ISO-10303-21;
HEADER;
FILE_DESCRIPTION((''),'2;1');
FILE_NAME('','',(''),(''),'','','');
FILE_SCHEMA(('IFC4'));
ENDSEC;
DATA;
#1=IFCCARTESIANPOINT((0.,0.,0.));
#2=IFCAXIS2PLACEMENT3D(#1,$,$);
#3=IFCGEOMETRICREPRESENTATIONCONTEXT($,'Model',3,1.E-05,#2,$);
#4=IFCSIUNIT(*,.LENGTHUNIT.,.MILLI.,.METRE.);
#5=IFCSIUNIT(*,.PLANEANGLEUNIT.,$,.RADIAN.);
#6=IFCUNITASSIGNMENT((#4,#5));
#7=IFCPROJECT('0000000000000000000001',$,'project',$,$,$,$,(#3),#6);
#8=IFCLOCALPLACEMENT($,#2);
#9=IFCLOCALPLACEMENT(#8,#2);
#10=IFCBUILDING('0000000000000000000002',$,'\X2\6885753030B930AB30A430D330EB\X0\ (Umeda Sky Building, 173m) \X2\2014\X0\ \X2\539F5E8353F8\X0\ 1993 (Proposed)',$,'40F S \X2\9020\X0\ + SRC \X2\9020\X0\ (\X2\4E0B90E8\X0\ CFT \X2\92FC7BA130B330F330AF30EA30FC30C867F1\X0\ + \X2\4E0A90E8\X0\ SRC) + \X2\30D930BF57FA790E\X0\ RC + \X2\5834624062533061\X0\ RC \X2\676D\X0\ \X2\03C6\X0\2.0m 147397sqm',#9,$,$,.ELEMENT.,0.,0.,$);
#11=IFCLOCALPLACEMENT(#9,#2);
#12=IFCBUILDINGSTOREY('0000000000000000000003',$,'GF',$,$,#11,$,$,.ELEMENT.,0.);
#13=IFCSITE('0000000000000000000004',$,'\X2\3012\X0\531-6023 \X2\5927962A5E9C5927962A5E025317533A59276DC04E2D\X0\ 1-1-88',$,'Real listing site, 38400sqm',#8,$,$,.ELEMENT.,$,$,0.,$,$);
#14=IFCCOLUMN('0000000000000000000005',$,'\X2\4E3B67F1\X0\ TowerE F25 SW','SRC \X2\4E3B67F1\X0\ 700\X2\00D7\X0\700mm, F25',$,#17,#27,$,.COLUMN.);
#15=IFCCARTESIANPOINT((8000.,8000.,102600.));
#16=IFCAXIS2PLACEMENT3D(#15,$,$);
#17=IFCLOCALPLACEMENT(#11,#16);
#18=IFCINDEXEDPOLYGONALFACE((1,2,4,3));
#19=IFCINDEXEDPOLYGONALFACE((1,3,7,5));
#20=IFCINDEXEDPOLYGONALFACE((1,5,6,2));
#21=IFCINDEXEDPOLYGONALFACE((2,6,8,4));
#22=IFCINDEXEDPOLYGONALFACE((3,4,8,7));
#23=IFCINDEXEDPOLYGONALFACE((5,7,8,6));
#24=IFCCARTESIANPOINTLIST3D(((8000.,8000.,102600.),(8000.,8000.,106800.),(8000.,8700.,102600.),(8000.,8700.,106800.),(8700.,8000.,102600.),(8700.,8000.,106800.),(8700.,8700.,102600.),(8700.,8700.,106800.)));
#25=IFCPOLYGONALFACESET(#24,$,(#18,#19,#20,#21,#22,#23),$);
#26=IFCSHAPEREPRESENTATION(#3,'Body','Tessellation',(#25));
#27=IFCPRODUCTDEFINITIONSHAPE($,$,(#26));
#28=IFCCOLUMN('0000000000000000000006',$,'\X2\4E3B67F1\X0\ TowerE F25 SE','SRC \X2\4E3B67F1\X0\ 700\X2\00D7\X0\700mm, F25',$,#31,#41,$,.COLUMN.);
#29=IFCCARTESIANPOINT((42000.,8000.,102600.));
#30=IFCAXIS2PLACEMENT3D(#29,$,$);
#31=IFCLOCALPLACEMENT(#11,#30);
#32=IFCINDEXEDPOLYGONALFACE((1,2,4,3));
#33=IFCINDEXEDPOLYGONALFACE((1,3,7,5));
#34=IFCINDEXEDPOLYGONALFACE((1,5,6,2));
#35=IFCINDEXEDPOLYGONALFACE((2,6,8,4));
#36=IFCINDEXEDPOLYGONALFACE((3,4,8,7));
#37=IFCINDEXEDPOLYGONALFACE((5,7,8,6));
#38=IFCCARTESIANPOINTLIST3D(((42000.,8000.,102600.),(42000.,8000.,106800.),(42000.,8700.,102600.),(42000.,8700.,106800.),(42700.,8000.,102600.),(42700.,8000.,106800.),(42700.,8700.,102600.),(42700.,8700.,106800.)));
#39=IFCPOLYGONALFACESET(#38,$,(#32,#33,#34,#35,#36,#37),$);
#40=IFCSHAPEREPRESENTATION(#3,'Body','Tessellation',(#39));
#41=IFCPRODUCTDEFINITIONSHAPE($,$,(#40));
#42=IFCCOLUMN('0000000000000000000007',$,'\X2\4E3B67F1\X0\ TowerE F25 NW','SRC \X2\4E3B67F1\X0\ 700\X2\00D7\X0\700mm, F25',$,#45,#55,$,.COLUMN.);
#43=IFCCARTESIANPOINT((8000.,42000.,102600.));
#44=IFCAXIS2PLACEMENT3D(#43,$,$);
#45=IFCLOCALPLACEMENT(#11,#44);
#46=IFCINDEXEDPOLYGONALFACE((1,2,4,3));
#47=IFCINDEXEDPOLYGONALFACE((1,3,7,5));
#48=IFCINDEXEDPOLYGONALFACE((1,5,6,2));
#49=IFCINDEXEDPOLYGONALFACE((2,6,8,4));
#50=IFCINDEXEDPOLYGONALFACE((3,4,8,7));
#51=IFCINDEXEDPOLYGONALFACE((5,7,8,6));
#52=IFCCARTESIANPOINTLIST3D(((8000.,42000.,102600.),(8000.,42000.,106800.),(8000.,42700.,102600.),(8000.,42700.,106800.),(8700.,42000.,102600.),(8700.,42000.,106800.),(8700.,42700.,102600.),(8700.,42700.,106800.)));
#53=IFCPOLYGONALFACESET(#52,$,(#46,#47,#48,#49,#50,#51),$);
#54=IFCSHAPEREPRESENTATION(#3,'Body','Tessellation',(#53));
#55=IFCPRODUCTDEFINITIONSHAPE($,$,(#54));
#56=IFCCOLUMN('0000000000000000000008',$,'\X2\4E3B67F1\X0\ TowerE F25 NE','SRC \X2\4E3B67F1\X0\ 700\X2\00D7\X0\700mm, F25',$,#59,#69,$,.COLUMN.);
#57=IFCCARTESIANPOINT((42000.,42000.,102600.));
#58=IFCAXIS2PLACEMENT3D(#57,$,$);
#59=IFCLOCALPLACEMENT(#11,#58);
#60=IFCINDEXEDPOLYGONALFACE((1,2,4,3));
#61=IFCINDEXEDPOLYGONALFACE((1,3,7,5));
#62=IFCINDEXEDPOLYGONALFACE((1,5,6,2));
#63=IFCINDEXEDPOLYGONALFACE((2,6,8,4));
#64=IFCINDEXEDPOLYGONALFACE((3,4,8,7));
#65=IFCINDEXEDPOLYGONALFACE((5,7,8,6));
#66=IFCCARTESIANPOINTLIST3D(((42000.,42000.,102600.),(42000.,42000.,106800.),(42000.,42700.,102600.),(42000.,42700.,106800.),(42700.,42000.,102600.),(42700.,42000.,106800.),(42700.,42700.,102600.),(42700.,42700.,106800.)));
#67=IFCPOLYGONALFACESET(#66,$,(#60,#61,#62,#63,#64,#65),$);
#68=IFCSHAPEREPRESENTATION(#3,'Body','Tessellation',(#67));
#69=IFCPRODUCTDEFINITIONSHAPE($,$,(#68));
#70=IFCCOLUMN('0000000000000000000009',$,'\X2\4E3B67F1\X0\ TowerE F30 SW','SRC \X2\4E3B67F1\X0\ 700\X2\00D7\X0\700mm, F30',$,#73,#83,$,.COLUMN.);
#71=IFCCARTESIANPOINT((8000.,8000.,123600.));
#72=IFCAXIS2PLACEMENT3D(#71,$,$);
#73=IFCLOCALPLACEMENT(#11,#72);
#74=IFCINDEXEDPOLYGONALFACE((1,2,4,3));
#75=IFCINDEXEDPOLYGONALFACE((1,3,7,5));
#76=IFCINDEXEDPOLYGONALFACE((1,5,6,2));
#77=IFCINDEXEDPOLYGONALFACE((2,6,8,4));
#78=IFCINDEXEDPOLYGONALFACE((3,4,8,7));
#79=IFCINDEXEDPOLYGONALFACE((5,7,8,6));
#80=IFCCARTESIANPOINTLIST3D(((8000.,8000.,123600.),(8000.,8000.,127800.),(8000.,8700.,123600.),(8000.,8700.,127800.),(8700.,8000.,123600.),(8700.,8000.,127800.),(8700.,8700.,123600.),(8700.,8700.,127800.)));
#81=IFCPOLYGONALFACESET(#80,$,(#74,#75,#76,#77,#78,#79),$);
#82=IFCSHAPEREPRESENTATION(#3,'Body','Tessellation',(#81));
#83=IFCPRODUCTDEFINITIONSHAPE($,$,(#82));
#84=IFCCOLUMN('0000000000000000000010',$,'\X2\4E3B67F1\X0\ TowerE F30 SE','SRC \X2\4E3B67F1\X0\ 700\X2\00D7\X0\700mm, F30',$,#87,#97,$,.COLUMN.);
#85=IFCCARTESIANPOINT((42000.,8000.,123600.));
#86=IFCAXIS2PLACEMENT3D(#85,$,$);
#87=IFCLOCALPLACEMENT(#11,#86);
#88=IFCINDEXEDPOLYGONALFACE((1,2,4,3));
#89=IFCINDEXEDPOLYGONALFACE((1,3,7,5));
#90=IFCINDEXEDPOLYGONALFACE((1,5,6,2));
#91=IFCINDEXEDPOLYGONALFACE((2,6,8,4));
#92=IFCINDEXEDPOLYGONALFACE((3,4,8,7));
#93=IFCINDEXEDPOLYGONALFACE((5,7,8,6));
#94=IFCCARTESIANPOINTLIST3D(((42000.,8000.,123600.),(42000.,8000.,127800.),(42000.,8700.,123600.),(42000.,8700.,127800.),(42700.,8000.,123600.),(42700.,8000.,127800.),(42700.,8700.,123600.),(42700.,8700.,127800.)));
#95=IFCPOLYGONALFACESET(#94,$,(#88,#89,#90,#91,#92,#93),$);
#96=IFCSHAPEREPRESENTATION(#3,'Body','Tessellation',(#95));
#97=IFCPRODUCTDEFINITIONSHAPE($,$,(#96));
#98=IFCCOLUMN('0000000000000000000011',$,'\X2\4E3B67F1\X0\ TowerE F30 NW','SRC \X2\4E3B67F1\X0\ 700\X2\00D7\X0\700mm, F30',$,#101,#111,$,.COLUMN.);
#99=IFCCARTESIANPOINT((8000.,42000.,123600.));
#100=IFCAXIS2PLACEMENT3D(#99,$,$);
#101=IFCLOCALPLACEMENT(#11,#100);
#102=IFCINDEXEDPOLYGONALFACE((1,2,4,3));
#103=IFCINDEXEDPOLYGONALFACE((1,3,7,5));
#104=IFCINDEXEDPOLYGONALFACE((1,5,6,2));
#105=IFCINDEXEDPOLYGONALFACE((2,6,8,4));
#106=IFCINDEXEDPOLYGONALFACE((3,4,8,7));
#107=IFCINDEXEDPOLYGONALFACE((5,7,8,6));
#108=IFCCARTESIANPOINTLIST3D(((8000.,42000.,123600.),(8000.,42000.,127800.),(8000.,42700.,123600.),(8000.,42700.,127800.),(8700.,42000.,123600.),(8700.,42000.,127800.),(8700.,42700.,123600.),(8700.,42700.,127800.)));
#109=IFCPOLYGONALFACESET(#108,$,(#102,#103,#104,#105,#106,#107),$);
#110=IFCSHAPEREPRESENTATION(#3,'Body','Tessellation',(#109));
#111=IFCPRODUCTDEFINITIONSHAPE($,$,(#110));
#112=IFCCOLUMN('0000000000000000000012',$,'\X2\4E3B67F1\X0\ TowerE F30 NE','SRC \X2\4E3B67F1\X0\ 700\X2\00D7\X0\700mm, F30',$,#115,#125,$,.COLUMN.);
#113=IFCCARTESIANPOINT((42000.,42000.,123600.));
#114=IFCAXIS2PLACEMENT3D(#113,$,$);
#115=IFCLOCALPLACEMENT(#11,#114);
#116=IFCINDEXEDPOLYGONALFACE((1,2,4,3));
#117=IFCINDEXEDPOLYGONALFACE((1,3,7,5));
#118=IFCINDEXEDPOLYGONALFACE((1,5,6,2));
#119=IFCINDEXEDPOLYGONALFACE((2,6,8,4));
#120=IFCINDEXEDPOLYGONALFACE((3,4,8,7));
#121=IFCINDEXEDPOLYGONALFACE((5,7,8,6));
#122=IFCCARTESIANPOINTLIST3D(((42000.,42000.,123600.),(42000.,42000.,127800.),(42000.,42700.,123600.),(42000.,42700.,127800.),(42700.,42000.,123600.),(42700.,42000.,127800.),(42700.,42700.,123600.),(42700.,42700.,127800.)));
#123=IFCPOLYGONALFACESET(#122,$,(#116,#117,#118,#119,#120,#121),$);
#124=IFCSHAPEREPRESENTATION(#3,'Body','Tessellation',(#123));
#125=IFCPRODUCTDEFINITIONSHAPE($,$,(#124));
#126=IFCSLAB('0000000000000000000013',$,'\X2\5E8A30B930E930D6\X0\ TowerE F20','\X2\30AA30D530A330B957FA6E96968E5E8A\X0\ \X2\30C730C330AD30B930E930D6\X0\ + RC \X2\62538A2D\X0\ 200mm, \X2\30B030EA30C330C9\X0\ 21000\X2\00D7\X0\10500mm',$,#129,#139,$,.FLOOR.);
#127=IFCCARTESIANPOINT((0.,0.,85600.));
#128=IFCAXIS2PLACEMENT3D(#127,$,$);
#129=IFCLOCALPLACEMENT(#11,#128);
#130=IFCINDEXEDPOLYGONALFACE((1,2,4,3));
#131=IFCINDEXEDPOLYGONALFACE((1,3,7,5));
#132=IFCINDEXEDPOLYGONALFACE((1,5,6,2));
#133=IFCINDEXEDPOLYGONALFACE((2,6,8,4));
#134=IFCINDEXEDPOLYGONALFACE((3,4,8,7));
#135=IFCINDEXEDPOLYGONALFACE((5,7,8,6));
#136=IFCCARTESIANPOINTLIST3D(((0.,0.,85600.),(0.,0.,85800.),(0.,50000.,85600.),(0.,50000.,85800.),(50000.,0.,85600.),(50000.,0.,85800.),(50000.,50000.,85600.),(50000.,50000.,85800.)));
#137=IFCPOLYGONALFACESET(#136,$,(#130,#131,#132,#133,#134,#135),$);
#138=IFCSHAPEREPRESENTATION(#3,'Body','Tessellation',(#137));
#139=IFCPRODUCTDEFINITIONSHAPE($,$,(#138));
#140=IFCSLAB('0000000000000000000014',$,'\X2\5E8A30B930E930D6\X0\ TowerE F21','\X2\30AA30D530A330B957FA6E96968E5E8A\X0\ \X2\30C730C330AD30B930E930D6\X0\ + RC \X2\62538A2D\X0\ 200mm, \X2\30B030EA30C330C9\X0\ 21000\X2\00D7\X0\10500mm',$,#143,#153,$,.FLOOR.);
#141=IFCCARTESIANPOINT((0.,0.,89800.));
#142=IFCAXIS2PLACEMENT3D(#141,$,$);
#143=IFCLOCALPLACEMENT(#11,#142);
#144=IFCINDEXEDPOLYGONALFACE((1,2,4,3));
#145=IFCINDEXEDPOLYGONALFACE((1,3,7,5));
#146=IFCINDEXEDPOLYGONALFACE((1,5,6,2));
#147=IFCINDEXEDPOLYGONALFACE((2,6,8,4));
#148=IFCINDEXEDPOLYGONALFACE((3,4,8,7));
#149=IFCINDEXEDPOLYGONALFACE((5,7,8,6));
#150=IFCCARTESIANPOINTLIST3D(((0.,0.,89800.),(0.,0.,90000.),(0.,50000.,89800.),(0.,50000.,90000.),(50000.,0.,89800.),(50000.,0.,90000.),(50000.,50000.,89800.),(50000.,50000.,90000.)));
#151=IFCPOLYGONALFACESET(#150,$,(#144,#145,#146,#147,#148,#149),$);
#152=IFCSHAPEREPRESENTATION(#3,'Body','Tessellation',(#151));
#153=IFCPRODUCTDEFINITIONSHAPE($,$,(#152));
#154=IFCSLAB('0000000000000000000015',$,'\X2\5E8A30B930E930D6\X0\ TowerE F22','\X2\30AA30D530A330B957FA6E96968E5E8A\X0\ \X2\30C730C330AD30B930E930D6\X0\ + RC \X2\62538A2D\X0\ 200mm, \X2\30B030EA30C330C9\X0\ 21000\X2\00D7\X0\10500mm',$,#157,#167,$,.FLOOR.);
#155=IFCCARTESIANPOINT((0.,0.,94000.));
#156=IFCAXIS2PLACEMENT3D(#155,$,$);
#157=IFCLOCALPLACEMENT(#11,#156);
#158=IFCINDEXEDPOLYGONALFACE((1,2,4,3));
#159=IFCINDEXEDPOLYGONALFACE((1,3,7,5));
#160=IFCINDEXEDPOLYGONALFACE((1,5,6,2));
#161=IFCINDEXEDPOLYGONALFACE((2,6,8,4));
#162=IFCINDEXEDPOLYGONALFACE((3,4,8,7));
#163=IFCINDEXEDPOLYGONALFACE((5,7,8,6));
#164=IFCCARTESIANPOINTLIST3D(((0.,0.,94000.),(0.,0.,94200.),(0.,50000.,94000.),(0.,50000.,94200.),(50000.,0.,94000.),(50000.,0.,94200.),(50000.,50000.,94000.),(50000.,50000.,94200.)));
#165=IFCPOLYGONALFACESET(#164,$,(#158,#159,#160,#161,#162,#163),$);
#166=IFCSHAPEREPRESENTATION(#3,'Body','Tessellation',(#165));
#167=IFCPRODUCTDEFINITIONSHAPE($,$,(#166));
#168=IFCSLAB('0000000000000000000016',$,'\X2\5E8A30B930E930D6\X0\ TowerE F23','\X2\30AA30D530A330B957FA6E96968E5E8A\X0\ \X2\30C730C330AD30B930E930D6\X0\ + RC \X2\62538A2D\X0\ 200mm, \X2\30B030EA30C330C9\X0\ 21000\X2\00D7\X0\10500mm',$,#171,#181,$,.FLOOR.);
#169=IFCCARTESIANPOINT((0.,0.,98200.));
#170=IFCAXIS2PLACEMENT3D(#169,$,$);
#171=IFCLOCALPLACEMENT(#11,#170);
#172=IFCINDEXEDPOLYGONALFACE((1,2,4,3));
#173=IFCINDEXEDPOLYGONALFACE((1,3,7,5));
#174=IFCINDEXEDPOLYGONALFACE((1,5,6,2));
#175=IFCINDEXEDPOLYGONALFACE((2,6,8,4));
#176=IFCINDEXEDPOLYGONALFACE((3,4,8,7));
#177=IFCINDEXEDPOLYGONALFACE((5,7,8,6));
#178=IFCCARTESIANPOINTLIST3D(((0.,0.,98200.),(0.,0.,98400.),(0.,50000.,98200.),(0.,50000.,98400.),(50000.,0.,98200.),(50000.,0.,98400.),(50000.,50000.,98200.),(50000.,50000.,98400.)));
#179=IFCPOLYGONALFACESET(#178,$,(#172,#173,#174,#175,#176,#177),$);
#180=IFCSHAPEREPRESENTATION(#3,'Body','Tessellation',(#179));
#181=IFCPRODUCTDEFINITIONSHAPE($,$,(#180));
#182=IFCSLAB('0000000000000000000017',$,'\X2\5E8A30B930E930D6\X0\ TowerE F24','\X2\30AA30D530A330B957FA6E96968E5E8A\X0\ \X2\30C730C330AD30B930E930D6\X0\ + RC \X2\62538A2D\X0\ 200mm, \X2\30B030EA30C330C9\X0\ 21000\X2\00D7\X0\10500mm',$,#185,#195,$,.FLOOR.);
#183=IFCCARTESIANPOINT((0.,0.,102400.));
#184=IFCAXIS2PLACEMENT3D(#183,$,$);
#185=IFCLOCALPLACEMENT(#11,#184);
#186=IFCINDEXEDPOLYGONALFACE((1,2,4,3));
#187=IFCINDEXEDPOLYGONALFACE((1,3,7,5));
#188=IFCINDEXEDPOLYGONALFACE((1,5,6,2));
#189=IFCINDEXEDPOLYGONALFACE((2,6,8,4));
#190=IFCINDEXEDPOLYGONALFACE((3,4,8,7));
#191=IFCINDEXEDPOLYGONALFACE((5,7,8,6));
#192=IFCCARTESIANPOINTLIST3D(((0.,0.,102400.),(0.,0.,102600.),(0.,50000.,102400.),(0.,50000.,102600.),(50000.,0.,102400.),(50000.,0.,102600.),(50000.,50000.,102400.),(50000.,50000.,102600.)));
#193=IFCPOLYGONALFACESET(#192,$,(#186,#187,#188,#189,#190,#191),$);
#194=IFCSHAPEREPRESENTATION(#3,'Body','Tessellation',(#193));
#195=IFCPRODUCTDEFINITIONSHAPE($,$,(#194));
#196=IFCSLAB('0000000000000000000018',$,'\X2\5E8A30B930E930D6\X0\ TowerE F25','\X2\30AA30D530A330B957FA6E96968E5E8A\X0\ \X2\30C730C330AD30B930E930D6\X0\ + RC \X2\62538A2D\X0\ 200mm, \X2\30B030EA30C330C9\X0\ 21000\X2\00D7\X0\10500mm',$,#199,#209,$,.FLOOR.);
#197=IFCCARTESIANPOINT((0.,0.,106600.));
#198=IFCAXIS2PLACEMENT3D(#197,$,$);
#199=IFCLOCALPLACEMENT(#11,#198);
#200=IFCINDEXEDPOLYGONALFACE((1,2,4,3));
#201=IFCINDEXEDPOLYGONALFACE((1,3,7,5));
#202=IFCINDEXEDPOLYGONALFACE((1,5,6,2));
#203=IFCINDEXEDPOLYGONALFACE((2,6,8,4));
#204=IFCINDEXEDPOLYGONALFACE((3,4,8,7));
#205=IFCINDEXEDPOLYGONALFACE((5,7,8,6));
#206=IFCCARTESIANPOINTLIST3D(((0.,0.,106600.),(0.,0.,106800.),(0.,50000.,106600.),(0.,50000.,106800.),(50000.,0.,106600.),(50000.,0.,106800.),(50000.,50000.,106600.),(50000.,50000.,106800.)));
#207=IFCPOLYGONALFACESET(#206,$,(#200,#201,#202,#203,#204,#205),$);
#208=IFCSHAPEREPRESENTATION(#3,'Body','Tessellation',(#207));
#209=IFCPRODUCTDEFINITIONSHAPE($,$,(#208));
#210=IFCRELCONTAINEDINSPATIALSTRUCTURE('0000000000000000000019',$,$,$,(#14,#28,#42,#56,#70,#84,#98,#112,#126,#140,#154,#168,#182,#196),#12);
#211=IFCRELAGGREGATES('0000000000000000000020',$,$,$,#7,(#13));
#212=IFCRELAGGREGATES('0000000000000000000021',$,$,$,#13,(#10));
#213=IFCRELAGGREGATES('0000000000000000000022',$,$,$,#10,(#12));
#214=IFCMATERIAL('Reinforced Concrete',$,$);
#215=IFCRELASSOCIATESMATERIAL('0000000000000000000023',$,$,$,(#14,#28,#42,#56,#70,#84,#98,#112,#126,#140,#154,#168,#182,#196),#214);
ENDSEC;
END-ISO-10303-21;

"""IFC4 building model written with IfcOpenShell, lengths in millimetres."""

from ifc_helpers import new_model, si_unit, frame, frame_2d, origin, place, context, project, spatial, rectangle, extrude, material, element, save


model = new_model("IFC4")

# Units and contexts
model_context = context("Model", 3, precision=1e-05, world=origin())
ifc_project = project(units=[si_unit("LENGTHUNIT", "METRE", prefix="MILLI"), si_unit("PLANEANGLEUNIT", "RADIAN")], contexts=[model_context])

# Site, building, storey
site_placement = place(None, origin())
site = spatial("IfcSite", under=ifc_project, at=site_placement, Name="〒531-6023 大阪府大阪市北区大淀中 1-1-88", ObjectType="Real listing site, 38400sqm", CompositionType="ELEMENT", RefElevation=0.0)
building_placement = place(site_placement, origin())
building = spatial("IfcBuilding", under=site, at=building_placement, Name="梅田スカイビル (Umeda Sky Building, 173m) — 原広司 1993 (Proposed)", ObjectType="40F S 造 + SRC 造 (下部 CFT 鋼管コンクリート柱 + 上部 SRC) + ベタ基礎 RC + 場所打ち RC 杭 φ2.0m 147397sqm", CompositionType="ELEMENT", ElevationOfRefHeight=0.0, ElevationOfTerrain=0.0)
storey_placement = place(building_placement, origin())
storey = spatial("IfcBuildingStorey", under=building, at=storey_placement, Name="GF", CompositionType="ELEMENT", Elevation=0.0)

# Columns
ifc_material_1 = material(Name="Reinforced Concrete")
column_1_placement = place(storey_placement, frame((8000.0, 8000.0, 102600.0)))
element("IfcColumn", 1, at=column_1_placement, inside=storey, material=ifc_material_1, Name="主柱 TowerE F25 SW", Description="SRC 主柱 700×700mm, F25", PredefinedType="COLUMN", context=model_context, shape_type="SweptSolid", body=[
    extrude(rectangle(XDim=700.0, YDim=700.0, at=frame_2d((350.0, 350.0))), frame((8000.0, 8000.0, 102600.0)), (0.0, 0.0, 1.0), 4200.0),
])
column_2_placement = place(storey_placement, frame((42000.0, 8000.0, 102600.0)))
element("IfcColumn", 2, at=column_2_placement, inside=storey, material=ifc_material_1, Name="主柱 TowerE F25 SE", Description="SRC 主柱 700×700mm, F25", PredefinedType="COLUMN", context=model_context, shape_type="SweptSolid", body=[
    extrude(rectangle(XDim=700.0, YDim=700.0, at=frame_2d((350.0, 350.0))), frame((42000.0, 8000.0, 102600.0)), (0.0, 0.0, 1.0), 4200.0),
])
column_3_placement = place(storey_placement, frame((8000.0, 42000.0, 102600.0)))
element("IfcColumn", 3, at=column_3_placement, inside=storey, material=ifc_material_1, Name="主柱 TowerE F25 NW", Description="SRC 主柱 700×700mm, F25", PredefinedType="COLUMN", context=model_context, shape_type="SweptSolid", body=[
    extrude(rectangle(XDim=700.0, YDim=700.0, at=frame_2d((350.0, 350.0))), frame((8000.0, 42000.0, 102600.0)), (0.0, 0.0, 1.0), 4200.0),
])
column_4_placement = place(storey_placement, frame((42000.0, 42000.0, 102600.0)))
element("IfcColumn", 4, at=column_4_placement, inside=storey, material=ifc_material_1, Name="主柱 TowerE F25 NE", Description="SRC 主柱 700×700mm, F25", PredefinedType="COLUMN", context=model_context, shape_type="SweptSolid", body=[
    extrude(rectangle(XDim=700.0, YDim=700.0, at=frame_2d((350.0, 350.0))), frame((42000.0, 42000.0, 102600.0)), (0.0, 0.0, 1.0), 4200.0),
])
column_5_placement = place(storey_placement, frame((8000.0, 8000.0, 123600.0)))
element("IfcColumn", 5, at=column_5_placement, inside=storey, material=ifc_material_1, Name="主柱 TowerE F30 SW", Description="SRC 主柱 700×700mm, F30", PredefinedType="COLUMN", context=model_context, shape_type="SweptSolid", body=[
    extrude(rectangle(XDim=700.0, YDim=700.0, at=frame_2d((350.0, 350.0))), frame((8000.0, 8000.0, 123600.0)), (0.0, 0.0, 1.0), 4200.0),
])
column_6_placement = place(storey_placement, frame((42000.0, 8000.0, 123600.0)))
element("IfcColumn", 6, at=column_6_placement, inside=storey, material=ifc_material_1, Name="主柱 TowerE F30 SE", Description="SRC 主柱 700×700mm, F30", PredefinedType="COLUMN", context=model_context, shape_type="SweptSolid", body=[
    extrude(rectangle(XDim=700.0, YDim=700.0, at=frame_2d((350.0, 350.0))), frame((42000.0, 8000.0, 123600.0)), (0.0, 0.0, 1.0), 4200.0),
])
column_7_placement = place(storey_placement, frame((8000.0, 42000.0, 123600.0)))
element("IfcColumn", 7, at=column_7_placement, inside=storey, material=ifc_material_1, Name="主柱 TowerE F30 NW", Description="SRC 主柱 700×700mm, F30", PredefinedType="COLUMN", context=model_context, shape_type="SweptSolid", body=[
    extrude(rectangle(XDim=700.0, YDim=700.0, at=frame_2d((350.0, 350.0))), frame((8000.0, 42000.0, 123600.0)), (0.0, 0.0, 1.0), 4200.0),
])
column_8_placement = place(storey_placement, frame((42000.0, 42000.0, 123600.0)))
element("IfcColumn", 8, at=column_8_placement, inside=storey, material=ifc_material_1, Name="主柱 TowerE F30 NE", Description="SRC 主柱 700×700mm, F30", PredefinedType="COLUMN", context=model_context, shape_type="SweptSolid", body=[
    extrude(rectangle(XDim=700.0, YDim=700.0, at=frame_2d((350.0, 350.0))), frame((42000.0, 42000.0, 123600.0)), (0.0, 0.0, 1.0), 4200.0),
])

# Slabs
slab_1_placement = place(storey_placement, frame((0.0, 0.0, 85600.0)))
element("IfcSlab", 9, at=slab_1_placement, inside=storey, material=ifc_material_1, Name="床スラブ TowerE F20", Description="オフィス基準階床 デッキスラブ + RC 打設 200mm, グリッド 21000×10500mm", PredefinedType="FLOOR", context=model_context, shape_type="SweptSolid", body=[
    extrude(rectangle(XDim=50000.0, YDim=50000.0, at=frame_2d((25000.0, 25000.0))), frame((0.0, 0.0, 85600.0)), (0.0, 0.0, 1.0), 200.0),
])
slab_2_placement = place(storey_placement, frame((0.0, 0.0, 89800.0)))
element("IfcSlab", 10, at=slab_2_placement, inside=storey, material=ifc_material_1, Name="床スラブ TowerE F21", Description="オフィス基準階床 デッキスラブ + RC 打設 200mm, グリッド 21000×10500mm", PredefinedType="FLOOR", context=model_context, shape_type="SweptSolid", body=[
    extrude(rectangle(XDim=50000.0, YDim=50000.0, at=frame_2d((25000.0, 25000.0))), frame((0.0, 0.0, 89800.0)), (0.0, 0.0, 1.0), 200.0),
])
slab_3_placement = place(storey_placement, frame((0.0, 0.0, 94000.0)))
element("IfcSlab", 11, at=slab_3_placement, inside=storey, material=ifc_material_1, Name="床スラブ TowerE F22", Description="オフィス基準階床 デッキスラブ + RC 打設 200mm, グリッド 21000×10500mm", PredefinedType="FLOOR", context=model_context, shape_type="SweptSolid", body=[
    extrude(rectangle(XDim=50000.0, YDim=50000.0, at=frame_2d((25000.0, 25000.0))), frame((0.0, 0.0, 94000.0)), (0.0, 0.0, 1.0), 200.0),
])
slab_4_placement = place(storey_placement, frame((0.0, 0.0, 98200.0)))
element("IfcSlab", 12, at=slab_4_placement, inside=storey, material=ifc_material_1, Name="床スラブ TowerE F23", Description="オフィス基準階床 デッキスラブ + RC 打設 200mm, グリッド 21000×10500mm", PredefinedType="FLOOR", context=model_context, shape_type="SweptSolid", body=[
    extrude(rectangle(XDim=50000.0, YDim=50000.0, at=frame_2d((25000.0, 25000.0))), frame((0.0, 0.0, 98200.0)), (0.0, 0.0, 1.0), 200.0),
])
slab_5_placement = place(storey_placement, frame((0.0, 0.0, 102400.0)))
element("IfcSlab", 13, at=slab_5_placement, inside=storey, material=ifc_material_1, Name="床スラブ TowerE F24", Description="オフィス基準階床 デッキスラブ + RC 打設 200mm, グリッド 21000×10500mm", PredefinedType="FLOOR", context=model_context, shape_type="SweptSolid", body=[
    extrude(rectangle(XDim=50000.0, YDim=50000.0, at=frame_2d((25000.0, 25000.0))), frame((0.0, 0.0, 102400.0)), (0.0, 0.0, 1.0), 200.0),
])
slab_6_placement = place(storey_placement, frame((0.0, 0.0, 106600.0)))
element("IfcSlab", 14, at=slab_6_placement, inside=storey, material=ifc_material_1, Name="床スラブ TowerE F25", Description="オフィス基準階床 デッキスラブ + RC 打設 200mm, グリッド 21000×10500mm", PredefinedType="FLOOR", context=model_context, shape_type="SweptSolid", body=[
    extrude(rectangle(XDim=50000.0, YDim=50000.0, at=frame_2d((25000.0, 25000.0))), frame((0.0, 0.0, 106600.0)), (0.0, 0.0, 1.0), 200.0),
])

save(model, "model.ifc")
